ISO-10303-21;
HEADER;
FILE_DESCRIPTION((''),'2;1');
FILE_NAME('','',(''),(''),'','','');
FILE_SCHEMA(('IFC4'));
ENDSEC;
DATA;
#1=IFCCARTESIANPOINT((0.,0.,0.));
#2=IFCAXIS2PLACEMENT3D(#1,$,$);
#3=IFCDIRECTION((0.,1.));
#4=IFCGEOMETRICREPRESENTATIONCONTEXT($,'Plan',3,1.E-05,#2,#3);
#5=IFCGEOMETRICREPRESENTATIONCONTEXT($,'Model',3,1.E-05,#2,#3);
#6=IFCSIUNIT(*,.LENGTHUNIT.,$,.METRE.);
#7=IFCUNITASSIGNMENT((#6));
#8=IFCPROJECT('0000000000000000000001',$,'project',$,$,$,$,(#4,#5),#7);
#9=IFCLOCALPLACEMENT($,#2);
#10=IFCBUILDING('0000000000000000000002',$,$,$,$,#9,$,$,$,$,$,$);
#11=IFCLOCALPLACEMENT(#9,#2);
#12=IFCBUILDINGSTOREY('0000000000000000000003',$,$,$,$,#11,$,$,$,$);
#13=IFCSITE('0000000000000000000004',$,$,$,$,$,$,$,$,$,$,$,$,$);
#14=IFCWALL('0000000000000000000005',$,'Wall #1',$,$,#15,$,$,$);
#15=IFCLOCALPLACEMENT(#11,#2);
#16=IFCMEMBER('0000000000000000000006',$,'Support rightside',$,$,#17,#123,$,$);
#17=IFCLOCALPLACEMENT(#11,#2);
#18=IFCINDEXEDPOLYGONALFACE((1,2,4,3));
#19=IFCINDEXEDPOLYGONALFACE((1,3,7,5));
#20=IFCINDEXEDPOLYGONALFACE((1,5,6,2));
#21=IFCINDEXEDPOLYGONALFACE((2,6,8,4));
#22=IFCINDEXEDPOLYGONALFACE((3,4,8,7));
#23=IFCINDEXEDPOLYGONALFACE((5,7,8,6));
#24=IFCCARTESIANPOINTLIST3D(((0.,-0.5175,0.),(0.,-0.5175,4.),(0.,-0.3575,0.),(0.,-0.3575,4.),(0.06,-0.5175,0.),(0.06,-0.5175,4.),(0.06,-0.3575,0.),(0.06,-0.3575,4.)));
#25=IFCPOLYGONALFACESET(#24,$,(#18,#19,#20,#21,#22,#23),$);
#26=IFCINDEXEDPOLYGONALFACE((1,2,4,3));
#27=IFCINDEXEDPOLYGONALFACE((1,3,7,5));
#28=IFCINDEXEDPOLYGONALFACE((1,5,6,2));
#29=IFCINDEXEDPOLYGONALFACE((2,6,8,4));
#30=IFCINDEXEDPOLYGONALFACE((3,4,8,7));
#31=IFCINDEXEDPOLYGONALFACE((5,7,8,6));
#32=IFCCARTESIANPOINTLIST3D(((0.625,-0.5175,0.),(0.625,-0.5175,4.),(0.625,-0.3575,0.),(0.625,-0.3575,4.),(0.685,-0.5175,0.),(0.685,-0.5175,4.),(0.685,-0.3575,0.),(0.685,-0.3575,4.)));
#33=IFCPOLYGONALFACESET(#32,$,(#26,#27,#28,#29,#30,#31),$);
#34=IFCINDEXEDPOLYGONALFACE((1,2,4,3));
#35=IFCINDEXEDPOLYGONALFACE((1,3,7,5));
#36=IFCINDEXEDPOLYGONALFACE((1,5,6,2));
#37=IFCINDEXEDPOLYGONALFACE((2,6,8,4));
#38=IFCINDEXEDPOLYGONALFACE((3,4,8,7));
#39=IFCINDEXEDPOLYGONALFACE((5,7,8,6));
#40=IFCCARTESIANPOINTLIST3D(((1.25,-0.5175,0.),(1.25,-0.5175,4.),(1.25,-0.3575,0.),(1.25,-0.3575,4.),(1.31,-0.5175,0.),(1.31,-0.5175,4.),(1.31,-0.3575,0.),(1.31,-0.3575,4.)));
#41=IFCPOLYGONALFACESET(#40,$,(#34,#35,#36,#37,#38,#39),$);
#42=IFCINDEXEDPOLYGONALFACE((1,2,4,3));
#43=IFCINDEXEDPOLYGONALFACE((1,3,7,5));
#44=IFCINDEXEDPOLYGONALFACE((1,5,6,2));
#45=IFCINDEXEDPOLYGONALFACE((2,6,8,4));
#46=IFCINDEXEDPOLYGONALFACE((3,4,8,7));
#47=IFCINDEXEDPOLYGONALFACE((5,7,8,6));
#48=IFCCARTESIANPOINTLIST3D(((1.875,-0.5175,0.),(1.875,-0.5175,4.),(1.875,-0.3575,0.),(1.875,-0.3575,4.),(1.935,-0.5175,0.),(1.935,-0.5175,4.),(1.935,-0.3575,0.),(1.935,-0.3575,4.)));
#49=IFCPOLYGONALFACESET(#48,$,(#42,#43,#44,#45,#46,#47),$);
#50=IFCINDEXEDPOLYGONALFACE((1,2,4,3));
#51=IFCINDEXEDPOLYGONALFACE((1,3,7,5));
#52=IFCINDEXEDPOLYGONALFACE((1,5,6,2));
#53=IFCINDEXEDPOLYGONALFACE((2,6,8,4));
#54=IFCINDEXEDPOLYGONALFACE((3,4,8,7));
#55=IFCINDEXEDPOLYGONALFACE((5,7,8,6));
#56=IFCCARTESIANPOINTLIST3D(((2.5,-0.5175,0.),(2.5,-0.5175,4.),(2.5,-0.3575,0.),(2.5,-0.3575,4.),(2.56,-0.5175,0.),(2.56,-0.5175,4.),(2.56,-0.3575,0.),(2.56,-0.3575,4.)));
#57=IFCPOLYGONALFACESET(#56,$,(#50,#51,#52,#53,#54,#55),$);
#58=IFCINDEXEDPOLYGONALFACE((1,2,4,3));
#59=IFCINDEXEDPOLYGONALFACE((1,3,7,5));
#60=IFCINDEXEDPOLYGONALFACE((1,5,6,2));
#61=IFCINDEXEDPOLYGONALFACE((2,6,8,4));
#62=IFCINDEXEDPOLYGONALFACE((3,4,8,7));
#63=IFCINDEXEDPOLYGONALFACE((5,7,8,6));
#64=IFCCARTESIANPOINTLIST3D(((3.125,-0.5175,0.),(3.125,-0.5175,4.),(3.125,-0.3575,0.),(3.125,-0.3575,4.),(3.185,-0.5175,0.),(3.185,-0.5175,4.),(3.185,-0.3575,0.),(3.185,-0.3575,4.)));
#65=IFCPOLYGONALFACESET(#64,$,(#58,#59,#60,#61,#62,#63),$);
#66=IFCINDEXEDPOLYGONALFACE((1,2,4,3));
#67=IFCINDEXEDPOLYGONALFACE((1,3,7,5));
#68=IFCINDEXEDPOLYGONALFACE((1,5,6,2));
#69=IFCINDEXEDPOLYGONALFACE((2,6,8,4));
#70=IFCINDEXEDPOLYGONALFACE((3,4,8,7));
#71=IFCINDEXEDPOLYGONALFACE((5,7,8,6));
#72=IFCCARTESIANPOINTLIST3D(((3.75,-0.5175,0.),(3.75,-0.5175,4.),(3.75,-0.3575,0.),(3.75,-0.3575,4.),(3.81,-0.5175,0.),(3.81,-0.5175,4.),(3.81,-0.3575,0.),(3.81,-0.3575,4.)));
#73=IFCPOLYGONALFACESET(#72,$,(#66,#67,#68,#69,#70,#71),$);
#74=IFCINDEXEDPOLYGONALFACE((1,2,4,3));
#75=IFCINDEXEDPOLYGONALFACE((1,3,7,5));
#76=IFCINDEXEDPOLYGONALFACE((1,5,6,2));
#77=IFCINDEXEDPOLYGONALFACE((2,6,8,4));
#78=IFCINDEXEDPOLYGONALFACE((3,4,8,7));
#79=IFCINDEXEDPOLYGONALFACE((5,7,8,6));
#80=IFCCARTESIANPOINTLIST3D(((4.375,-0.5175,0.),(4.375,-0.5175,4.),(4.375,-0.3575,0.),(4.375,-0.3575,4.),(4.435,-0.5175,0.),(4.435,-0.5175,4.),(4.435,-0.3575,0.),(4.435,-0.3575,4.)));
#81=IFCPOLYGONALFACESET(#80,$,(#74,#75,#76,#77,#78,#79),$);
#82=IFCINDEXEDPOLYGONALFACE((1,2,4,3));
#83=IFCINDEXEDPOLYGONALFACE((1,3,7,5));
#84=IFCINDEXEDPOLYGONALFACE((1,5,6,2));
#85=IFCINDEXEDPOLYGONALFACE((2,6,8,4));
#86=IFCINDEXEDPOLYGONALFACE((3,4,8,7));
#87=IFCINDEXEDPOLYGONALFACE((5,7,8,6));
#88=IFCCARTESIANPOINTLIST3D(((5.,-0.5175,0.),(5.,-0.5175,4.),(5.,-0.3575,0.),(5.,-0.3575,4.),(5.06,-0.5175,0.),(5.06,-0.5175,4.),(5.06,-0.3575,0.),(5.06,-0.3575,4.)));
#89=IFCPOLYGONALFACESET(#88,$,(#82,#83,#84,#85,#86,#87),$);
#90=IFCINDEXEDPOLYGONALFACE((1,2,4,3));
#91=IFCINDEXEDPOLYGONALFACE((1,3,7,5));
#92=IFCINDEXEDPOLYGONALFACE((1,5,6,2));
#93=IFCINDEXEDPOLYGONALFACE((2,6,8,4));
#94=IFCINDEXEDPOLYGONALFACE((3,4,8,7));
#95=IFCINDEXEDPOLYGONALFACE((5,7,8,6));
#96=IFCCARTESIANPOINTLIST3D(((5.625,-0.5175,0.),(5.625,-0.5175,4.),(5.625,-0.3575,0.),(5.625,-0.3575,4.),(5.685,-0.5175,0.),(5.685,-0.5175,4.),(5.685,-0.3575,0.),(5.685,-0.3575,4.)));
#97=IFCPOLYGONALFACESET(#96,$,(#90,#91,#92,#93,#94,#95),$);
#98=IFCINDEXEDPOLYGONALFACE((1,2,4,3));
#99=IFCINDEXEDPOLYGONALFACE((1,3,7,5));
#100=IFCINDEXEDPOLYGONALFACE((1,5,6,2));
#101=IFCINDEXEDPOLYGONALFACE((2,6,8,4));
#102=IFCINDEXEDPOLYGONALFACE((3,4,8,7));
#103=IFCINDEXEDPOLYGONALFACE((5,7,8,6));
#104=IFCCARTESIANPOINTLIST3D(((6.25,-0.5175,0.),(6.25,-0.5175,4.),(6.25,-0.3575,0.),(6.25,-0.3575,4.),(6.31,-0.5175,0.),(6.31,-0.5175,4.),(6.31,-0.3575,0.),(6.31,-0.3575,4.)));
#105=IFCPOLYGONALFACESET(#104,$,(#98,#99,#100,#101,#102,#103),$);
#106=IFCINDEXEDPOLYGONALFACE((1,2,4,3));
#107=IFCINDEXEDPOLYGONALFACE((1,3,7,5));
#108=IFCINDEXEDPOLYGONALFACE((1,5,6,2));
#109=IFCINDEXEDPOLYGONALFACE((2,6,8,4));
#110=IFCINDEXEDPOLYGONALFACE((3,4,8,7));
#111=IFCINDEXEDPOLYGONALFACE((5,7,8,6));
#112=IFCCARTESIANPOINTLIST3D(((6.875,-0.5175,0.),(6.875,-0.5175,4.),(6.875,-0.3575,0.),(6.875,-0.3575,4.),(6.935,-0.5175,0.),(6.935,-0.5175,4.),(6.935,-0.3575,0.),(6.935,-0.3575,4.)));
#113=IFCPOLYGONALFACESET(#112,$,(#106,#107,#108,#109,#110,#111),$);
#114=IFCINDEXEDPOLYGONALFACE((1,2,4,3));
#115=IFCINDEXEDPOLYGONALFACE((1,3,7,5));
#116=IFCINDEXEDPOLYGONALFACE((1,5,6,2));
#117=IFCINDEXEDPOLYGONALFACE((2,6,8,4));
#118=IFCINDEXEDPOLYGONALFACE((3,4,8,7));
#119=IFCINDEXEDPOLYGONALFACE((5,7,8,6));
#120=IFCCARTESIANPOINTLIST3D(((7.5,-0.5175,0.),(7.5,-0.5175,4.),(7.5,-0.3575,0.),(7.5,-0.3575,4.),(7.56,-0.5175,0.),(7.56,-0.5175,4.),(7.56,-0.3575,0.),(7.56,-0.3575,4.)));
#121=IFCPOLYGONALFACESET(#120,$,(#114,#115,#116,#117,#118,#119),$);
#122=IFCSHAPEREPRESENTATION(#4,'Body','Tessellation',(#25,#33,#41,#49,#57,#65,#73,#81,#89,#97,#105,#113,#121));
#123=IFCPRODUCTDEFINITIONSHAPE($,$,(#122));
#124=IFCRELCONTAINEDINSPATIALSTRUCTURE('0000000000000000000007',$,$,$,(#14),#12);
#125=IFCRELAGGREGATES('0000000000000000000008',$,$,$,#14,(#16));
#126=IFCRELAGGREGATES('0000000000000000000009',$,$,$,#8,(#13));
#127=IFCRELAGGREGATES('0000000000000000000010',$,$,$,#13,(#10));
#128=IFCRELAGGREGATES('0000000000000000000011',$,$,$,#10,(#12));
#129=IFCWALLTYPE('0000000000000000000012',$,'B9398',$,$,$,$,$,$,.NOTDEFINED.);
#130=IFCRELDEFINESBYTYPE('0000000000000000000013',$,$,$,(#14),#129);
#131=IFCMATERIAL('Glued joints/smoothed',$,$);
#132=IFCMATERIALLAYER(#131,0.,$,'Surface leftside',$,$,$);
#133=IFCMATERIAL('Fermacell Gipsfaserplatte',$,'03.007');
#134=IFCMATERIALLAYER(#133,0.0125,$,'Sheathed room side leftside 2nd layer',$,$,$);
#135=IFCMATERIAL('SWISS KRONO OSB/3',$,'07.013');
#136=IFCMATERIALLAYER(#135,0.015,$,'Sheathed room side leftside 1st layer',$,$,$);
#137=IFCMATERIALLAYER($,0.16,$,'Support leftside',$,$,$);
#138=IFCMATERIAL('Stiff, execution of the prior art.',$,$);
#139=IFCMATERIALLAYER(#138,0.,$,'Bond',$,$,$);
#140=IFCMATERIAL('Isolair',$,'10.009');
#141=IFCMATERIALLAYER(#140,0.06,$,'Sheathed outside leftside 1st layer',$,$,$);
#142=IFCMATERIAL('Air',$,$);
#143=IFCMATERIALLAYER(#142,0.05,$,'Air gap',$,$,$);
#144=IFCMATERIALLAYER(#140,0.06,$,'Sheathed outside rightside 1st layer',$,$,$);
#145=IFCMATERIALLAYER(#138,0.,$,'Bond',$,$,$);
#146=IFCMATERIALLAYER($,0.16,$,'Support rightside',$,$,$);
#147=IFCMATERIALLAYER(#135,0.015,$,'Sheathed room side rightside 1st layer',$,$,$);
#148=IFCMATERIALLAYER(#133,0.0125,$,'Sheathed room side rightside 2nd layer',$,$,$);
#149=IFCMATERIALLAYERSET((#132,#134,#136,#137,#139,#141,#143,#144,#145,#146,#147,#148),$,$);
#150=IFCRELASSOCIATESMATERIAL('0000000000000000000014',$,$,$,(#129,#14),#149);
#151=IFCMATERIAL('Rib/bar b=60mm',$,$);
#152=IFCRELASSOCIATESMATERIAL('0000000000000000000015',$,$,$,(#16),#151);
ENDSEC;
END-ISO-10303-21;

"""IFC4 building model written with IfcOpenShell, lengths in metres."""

from ifc_helpers import new_model, si_unit, direction, frame, frame_2d, origin, place, context, project, spatial, rectangle, extrude, material, layer, layer_set, type_object, element, aggregate, save


model = new_model("IFC4")

# Units and contexts
plan_context = context("Plan", 3, precision=1e-05, world=origin(), true_north=direction((0.0, 1.0)))
model_context = context("Model", 3, precision=1e-05, world=origin(), true_north=direction((0.0, 1.0)))
ifc_project = project(units=[si_unit("LENGTHUNIT", "METRE")], contexts=[plan_context, model_context])

# Site, building, storey
site = spatial("IfcSite", under=ifc_project)
building_placement = place(None, origin())
building = spatial("IfcBuilding", under=site, at=building_placement)
storey_placement = place(building_placement, origin())
storey = spatial("IfcBuildingStorey", under=building, at=storey_placement)

# Wall, member
ifc_material_1 = material(Name="Glued joints/smoothed")
ifc_layer_1 = layer(ifc_material_1, 0.0, Name="Surface leftside")
ifc_material_2 = material(Name="Fermacell Gipsfaserplatte", Category="03.007")
ifc_layer_2 = layer(ifc_material_2, 0.0125, Name="Sheathed room side leftside 2nd layer")
ifc_material_3 = material(Name="SWISS KRONO OSB/3", Category="07.013")
ifc_layer_3 = layer(ifc_material_3, 0.015, Name="Sheathed room side leftside 1st layer")
ifc_layer_4 = layer(None, 0.16, Name="Support leftside")
ifc_material_4 = material(Name="Stiff, execution of the prior art.")
ifc_layer_5 = layer(ifc_material_4, 0.0, Name="Bond")
ifc_material_5 = material(Name="Isolair", Category="10.009")
ifc_layer_6 = layer(ifc_material_5, 0.06, Name="Sheathed outside leftside 1st layer")
ifc_material_6 = material(Name="Air")
ifc_layer_7 = layer(ifc_material_6, 0.05, Name="Air gap")
ifc_layer_8 = layer(ifc_material_5, 0.06, Name="Sheathed outside rightside 1st layer")
ifc_layer_9 = layer(ifc_material_4, 0.0, Name="Bond")
ifc_layer_10 = layer(None, 0.16, Name="Support rightside")
ifc_layer_11 = layer(ifc_material_3, 0.015, Name="Sheathed room side rightside 1st layer")
ifc_layer_12 = layer(ifc_material_2, 0.0125, Name="Sheathed room side rightside 2nd layer")
ifc_layer_set = layer_set([ifc_layer_1, ifc_layer_2, ifc_layer_3, ifc_layer_4, ifc_layer_5, ifc_layer_6, ifc_layer_7, ifc_layer_8, ifc_layer_9, ifc_layer_10, ifc_layer_11, ifc_layer_12])
wall_type = type_object("IfcWallType", Name="B9398", PredefinedType="NOTDEFINED", material=ifc_layer_set)
wall_placement = place(None, frame((0.0, 0.0, 0.0), z_axis=(0.0, -1.0, 0.0), x_axis=(1.0, 0.0, 0.0)))
wall = element("IfcWall", 1, at=wall_placement, inside=storey, type_object=wall_type, material=ifc_layer_set, Name="Wall #1")
ifc_material_7 = material(Name="Rib/bar b=60mm")
member_1_placement = place(wall_placement, origin())
member_1 = element("IfcMember", 2, at=member_1_placement, material=ifc_material_7, Name="Support rightside", context=plan_context, shape_type="SweptSolid", body=[
    extrude(rectangle(XDim=0.06, YDim=0.16, at=frame_2d((0.03, 0.08), x_axis=(1.0, 0.0))), frame((0.0, 4.0, 0.3575), z_axis=(0.0, -1.0, 0.0), x_axis=(1.0, 0.0, 0.0)), (0.0, 0.0, 1.0), 4.0),
    extrude(rectangle(XDim=0.06, YDim=0.16, at=frame_2d((0.03, 0.08), x_axis=(1.0, 0.0))), frame((0.625, 4.0, 0.3575), z_axis=(0.0, -1.0, 0.0), x_axis=(1.0, 0.0, 0.0)), (0.0, 0.0, 1.0), 4.0),
    extrude(rectangle(XDim=0.06, YDim=0.16, at=frame_2d((0.03, 0.08), x_axis=(1.0, 0.0))), frame((1.25, 4.0, 0.3575), z_axis=(0.0, -1.0, 0.0), x_axis=(1.0, 0.0, 0.0)), (0.0, 0.0, 1.0), 4.0),
    extrude(rectangle(XDim=0.06, YDim=0.16, at=frame_2d((0.03, 0.08), x_axis=(1.0, 0.0))), frame((1.875, 4.0, 0.3575), z_axis=(0.0, -1.0, 0.0), x_axis=(1.0, 0.0, 0.0)), (0.0, 0.0, 1.0), 4.0),
    extrude(rectangle(XDim=0.06, YDim=0.16, at=frame_2d((0.03, 0.08), x_axis=(1.0, 0.0))), frame((2.5, 4.0, 0.3575), z_axis=(0.0, -1.0, 0.0), x_axis=(1.0, 0.0, 0.0)), (0.0, 0.0, 1.0), 4.0),
    extrude(rectangle(XDim=0.06, YDim=0.16, at=frame_2d((0.03, 0.08), x_axis=(1.0, 0.0))), frame((3.125, 4.0, 0.3575), z_axis=(0.0, -1.0, 0.0), x_axis=(1.0, 0.0, 0.0)), (0.0, 0.0, 1.0), 4.0),
    extrude(rectangle(XDim=0.06, YDim=0.16, at=frame_2d((0.03, 0.08), x_axis=(1.0, 0.0))), frame((3.75, 4.0, 0.3575), z_axis=(0.0, -1.0, 0.0), x_axis=(1.0, 0.0, 0.0)), (0.0, 0.0, 1.0), 4.0),
    extrude(rectangle(XDim=0.06, YDim=0.16, at=frame_2d((0.03, 0.08), x_axis=(1.0, 0.0))), frame((4.375, 4.0, 0.3575), z_axis=(0.0, -1.0, 0.0), x_axis=(1.0, 0.0, 0.0)), (0.0, 0.0, 1.0), 4.0),
    extrude(rectangle(XDim=0.06, YDim=0.16, at=frame_2d((0.03, 0.08), x_axis=(1.0, 0.0))), frame((5.0, 4.0, 0.3575), z_axis=(0.0, -1.0, 0.0), x_axis=(1.0, 0.0, 0.0)), (0.0, 0.0, 1.0), 4.0),
    extrude(rectangle(XDim=0.06, YDim=0.16, at=frame_2d((0.03, 0.08), x_axis=(1.0, 0.0))), frame((5.625, 4.0, 0.3575), z_axis=(0.0, -1.0, 0.0), x_axis=(1.0, 0.0, 0.0)), (0.0, 0.0, 1.0), 4.0),
    extrude(rectangle(XDim=0.06, YDim=0.16, at=frame_2d((0.03, 0.08), x_axis=(1.0, 0.0))), frame((6.25, 4.0, 0.3575), z_axis=(0.0, -1.0, 0.0), x_axis=(1.0, 0.0, 0.0)), (0.0, 0.0, 1.0), 4.0),
    extrude(rectangle(XDim=0.06, YDim=0.16, at=frame_2d((0.03, 0.08), x_axis=(1.0, 0.0))), frame((6.875, 4.0, 0.3575), z_axis=(0.0, -1.0, 0.0), x_axis=(1.0, 0.0, 0.0)), (0.0, 0.0, 1.0), 4.0),
    extrude(rectangle(XDim=0.06, YDim=0.16, at=frame_2d((0.03, 0.08), x_axis=(1.0, 0.0))), frame((7.5, 4.0, 0.3575), z_axis=(0.0, -1.0, 0.0), x_axis=(1.0, 0.0, 0.0)), (0.0, 0.0, 1.0), 4.0),
])
aggregate(wall, [member_1])

save(model, "model.ifc")
